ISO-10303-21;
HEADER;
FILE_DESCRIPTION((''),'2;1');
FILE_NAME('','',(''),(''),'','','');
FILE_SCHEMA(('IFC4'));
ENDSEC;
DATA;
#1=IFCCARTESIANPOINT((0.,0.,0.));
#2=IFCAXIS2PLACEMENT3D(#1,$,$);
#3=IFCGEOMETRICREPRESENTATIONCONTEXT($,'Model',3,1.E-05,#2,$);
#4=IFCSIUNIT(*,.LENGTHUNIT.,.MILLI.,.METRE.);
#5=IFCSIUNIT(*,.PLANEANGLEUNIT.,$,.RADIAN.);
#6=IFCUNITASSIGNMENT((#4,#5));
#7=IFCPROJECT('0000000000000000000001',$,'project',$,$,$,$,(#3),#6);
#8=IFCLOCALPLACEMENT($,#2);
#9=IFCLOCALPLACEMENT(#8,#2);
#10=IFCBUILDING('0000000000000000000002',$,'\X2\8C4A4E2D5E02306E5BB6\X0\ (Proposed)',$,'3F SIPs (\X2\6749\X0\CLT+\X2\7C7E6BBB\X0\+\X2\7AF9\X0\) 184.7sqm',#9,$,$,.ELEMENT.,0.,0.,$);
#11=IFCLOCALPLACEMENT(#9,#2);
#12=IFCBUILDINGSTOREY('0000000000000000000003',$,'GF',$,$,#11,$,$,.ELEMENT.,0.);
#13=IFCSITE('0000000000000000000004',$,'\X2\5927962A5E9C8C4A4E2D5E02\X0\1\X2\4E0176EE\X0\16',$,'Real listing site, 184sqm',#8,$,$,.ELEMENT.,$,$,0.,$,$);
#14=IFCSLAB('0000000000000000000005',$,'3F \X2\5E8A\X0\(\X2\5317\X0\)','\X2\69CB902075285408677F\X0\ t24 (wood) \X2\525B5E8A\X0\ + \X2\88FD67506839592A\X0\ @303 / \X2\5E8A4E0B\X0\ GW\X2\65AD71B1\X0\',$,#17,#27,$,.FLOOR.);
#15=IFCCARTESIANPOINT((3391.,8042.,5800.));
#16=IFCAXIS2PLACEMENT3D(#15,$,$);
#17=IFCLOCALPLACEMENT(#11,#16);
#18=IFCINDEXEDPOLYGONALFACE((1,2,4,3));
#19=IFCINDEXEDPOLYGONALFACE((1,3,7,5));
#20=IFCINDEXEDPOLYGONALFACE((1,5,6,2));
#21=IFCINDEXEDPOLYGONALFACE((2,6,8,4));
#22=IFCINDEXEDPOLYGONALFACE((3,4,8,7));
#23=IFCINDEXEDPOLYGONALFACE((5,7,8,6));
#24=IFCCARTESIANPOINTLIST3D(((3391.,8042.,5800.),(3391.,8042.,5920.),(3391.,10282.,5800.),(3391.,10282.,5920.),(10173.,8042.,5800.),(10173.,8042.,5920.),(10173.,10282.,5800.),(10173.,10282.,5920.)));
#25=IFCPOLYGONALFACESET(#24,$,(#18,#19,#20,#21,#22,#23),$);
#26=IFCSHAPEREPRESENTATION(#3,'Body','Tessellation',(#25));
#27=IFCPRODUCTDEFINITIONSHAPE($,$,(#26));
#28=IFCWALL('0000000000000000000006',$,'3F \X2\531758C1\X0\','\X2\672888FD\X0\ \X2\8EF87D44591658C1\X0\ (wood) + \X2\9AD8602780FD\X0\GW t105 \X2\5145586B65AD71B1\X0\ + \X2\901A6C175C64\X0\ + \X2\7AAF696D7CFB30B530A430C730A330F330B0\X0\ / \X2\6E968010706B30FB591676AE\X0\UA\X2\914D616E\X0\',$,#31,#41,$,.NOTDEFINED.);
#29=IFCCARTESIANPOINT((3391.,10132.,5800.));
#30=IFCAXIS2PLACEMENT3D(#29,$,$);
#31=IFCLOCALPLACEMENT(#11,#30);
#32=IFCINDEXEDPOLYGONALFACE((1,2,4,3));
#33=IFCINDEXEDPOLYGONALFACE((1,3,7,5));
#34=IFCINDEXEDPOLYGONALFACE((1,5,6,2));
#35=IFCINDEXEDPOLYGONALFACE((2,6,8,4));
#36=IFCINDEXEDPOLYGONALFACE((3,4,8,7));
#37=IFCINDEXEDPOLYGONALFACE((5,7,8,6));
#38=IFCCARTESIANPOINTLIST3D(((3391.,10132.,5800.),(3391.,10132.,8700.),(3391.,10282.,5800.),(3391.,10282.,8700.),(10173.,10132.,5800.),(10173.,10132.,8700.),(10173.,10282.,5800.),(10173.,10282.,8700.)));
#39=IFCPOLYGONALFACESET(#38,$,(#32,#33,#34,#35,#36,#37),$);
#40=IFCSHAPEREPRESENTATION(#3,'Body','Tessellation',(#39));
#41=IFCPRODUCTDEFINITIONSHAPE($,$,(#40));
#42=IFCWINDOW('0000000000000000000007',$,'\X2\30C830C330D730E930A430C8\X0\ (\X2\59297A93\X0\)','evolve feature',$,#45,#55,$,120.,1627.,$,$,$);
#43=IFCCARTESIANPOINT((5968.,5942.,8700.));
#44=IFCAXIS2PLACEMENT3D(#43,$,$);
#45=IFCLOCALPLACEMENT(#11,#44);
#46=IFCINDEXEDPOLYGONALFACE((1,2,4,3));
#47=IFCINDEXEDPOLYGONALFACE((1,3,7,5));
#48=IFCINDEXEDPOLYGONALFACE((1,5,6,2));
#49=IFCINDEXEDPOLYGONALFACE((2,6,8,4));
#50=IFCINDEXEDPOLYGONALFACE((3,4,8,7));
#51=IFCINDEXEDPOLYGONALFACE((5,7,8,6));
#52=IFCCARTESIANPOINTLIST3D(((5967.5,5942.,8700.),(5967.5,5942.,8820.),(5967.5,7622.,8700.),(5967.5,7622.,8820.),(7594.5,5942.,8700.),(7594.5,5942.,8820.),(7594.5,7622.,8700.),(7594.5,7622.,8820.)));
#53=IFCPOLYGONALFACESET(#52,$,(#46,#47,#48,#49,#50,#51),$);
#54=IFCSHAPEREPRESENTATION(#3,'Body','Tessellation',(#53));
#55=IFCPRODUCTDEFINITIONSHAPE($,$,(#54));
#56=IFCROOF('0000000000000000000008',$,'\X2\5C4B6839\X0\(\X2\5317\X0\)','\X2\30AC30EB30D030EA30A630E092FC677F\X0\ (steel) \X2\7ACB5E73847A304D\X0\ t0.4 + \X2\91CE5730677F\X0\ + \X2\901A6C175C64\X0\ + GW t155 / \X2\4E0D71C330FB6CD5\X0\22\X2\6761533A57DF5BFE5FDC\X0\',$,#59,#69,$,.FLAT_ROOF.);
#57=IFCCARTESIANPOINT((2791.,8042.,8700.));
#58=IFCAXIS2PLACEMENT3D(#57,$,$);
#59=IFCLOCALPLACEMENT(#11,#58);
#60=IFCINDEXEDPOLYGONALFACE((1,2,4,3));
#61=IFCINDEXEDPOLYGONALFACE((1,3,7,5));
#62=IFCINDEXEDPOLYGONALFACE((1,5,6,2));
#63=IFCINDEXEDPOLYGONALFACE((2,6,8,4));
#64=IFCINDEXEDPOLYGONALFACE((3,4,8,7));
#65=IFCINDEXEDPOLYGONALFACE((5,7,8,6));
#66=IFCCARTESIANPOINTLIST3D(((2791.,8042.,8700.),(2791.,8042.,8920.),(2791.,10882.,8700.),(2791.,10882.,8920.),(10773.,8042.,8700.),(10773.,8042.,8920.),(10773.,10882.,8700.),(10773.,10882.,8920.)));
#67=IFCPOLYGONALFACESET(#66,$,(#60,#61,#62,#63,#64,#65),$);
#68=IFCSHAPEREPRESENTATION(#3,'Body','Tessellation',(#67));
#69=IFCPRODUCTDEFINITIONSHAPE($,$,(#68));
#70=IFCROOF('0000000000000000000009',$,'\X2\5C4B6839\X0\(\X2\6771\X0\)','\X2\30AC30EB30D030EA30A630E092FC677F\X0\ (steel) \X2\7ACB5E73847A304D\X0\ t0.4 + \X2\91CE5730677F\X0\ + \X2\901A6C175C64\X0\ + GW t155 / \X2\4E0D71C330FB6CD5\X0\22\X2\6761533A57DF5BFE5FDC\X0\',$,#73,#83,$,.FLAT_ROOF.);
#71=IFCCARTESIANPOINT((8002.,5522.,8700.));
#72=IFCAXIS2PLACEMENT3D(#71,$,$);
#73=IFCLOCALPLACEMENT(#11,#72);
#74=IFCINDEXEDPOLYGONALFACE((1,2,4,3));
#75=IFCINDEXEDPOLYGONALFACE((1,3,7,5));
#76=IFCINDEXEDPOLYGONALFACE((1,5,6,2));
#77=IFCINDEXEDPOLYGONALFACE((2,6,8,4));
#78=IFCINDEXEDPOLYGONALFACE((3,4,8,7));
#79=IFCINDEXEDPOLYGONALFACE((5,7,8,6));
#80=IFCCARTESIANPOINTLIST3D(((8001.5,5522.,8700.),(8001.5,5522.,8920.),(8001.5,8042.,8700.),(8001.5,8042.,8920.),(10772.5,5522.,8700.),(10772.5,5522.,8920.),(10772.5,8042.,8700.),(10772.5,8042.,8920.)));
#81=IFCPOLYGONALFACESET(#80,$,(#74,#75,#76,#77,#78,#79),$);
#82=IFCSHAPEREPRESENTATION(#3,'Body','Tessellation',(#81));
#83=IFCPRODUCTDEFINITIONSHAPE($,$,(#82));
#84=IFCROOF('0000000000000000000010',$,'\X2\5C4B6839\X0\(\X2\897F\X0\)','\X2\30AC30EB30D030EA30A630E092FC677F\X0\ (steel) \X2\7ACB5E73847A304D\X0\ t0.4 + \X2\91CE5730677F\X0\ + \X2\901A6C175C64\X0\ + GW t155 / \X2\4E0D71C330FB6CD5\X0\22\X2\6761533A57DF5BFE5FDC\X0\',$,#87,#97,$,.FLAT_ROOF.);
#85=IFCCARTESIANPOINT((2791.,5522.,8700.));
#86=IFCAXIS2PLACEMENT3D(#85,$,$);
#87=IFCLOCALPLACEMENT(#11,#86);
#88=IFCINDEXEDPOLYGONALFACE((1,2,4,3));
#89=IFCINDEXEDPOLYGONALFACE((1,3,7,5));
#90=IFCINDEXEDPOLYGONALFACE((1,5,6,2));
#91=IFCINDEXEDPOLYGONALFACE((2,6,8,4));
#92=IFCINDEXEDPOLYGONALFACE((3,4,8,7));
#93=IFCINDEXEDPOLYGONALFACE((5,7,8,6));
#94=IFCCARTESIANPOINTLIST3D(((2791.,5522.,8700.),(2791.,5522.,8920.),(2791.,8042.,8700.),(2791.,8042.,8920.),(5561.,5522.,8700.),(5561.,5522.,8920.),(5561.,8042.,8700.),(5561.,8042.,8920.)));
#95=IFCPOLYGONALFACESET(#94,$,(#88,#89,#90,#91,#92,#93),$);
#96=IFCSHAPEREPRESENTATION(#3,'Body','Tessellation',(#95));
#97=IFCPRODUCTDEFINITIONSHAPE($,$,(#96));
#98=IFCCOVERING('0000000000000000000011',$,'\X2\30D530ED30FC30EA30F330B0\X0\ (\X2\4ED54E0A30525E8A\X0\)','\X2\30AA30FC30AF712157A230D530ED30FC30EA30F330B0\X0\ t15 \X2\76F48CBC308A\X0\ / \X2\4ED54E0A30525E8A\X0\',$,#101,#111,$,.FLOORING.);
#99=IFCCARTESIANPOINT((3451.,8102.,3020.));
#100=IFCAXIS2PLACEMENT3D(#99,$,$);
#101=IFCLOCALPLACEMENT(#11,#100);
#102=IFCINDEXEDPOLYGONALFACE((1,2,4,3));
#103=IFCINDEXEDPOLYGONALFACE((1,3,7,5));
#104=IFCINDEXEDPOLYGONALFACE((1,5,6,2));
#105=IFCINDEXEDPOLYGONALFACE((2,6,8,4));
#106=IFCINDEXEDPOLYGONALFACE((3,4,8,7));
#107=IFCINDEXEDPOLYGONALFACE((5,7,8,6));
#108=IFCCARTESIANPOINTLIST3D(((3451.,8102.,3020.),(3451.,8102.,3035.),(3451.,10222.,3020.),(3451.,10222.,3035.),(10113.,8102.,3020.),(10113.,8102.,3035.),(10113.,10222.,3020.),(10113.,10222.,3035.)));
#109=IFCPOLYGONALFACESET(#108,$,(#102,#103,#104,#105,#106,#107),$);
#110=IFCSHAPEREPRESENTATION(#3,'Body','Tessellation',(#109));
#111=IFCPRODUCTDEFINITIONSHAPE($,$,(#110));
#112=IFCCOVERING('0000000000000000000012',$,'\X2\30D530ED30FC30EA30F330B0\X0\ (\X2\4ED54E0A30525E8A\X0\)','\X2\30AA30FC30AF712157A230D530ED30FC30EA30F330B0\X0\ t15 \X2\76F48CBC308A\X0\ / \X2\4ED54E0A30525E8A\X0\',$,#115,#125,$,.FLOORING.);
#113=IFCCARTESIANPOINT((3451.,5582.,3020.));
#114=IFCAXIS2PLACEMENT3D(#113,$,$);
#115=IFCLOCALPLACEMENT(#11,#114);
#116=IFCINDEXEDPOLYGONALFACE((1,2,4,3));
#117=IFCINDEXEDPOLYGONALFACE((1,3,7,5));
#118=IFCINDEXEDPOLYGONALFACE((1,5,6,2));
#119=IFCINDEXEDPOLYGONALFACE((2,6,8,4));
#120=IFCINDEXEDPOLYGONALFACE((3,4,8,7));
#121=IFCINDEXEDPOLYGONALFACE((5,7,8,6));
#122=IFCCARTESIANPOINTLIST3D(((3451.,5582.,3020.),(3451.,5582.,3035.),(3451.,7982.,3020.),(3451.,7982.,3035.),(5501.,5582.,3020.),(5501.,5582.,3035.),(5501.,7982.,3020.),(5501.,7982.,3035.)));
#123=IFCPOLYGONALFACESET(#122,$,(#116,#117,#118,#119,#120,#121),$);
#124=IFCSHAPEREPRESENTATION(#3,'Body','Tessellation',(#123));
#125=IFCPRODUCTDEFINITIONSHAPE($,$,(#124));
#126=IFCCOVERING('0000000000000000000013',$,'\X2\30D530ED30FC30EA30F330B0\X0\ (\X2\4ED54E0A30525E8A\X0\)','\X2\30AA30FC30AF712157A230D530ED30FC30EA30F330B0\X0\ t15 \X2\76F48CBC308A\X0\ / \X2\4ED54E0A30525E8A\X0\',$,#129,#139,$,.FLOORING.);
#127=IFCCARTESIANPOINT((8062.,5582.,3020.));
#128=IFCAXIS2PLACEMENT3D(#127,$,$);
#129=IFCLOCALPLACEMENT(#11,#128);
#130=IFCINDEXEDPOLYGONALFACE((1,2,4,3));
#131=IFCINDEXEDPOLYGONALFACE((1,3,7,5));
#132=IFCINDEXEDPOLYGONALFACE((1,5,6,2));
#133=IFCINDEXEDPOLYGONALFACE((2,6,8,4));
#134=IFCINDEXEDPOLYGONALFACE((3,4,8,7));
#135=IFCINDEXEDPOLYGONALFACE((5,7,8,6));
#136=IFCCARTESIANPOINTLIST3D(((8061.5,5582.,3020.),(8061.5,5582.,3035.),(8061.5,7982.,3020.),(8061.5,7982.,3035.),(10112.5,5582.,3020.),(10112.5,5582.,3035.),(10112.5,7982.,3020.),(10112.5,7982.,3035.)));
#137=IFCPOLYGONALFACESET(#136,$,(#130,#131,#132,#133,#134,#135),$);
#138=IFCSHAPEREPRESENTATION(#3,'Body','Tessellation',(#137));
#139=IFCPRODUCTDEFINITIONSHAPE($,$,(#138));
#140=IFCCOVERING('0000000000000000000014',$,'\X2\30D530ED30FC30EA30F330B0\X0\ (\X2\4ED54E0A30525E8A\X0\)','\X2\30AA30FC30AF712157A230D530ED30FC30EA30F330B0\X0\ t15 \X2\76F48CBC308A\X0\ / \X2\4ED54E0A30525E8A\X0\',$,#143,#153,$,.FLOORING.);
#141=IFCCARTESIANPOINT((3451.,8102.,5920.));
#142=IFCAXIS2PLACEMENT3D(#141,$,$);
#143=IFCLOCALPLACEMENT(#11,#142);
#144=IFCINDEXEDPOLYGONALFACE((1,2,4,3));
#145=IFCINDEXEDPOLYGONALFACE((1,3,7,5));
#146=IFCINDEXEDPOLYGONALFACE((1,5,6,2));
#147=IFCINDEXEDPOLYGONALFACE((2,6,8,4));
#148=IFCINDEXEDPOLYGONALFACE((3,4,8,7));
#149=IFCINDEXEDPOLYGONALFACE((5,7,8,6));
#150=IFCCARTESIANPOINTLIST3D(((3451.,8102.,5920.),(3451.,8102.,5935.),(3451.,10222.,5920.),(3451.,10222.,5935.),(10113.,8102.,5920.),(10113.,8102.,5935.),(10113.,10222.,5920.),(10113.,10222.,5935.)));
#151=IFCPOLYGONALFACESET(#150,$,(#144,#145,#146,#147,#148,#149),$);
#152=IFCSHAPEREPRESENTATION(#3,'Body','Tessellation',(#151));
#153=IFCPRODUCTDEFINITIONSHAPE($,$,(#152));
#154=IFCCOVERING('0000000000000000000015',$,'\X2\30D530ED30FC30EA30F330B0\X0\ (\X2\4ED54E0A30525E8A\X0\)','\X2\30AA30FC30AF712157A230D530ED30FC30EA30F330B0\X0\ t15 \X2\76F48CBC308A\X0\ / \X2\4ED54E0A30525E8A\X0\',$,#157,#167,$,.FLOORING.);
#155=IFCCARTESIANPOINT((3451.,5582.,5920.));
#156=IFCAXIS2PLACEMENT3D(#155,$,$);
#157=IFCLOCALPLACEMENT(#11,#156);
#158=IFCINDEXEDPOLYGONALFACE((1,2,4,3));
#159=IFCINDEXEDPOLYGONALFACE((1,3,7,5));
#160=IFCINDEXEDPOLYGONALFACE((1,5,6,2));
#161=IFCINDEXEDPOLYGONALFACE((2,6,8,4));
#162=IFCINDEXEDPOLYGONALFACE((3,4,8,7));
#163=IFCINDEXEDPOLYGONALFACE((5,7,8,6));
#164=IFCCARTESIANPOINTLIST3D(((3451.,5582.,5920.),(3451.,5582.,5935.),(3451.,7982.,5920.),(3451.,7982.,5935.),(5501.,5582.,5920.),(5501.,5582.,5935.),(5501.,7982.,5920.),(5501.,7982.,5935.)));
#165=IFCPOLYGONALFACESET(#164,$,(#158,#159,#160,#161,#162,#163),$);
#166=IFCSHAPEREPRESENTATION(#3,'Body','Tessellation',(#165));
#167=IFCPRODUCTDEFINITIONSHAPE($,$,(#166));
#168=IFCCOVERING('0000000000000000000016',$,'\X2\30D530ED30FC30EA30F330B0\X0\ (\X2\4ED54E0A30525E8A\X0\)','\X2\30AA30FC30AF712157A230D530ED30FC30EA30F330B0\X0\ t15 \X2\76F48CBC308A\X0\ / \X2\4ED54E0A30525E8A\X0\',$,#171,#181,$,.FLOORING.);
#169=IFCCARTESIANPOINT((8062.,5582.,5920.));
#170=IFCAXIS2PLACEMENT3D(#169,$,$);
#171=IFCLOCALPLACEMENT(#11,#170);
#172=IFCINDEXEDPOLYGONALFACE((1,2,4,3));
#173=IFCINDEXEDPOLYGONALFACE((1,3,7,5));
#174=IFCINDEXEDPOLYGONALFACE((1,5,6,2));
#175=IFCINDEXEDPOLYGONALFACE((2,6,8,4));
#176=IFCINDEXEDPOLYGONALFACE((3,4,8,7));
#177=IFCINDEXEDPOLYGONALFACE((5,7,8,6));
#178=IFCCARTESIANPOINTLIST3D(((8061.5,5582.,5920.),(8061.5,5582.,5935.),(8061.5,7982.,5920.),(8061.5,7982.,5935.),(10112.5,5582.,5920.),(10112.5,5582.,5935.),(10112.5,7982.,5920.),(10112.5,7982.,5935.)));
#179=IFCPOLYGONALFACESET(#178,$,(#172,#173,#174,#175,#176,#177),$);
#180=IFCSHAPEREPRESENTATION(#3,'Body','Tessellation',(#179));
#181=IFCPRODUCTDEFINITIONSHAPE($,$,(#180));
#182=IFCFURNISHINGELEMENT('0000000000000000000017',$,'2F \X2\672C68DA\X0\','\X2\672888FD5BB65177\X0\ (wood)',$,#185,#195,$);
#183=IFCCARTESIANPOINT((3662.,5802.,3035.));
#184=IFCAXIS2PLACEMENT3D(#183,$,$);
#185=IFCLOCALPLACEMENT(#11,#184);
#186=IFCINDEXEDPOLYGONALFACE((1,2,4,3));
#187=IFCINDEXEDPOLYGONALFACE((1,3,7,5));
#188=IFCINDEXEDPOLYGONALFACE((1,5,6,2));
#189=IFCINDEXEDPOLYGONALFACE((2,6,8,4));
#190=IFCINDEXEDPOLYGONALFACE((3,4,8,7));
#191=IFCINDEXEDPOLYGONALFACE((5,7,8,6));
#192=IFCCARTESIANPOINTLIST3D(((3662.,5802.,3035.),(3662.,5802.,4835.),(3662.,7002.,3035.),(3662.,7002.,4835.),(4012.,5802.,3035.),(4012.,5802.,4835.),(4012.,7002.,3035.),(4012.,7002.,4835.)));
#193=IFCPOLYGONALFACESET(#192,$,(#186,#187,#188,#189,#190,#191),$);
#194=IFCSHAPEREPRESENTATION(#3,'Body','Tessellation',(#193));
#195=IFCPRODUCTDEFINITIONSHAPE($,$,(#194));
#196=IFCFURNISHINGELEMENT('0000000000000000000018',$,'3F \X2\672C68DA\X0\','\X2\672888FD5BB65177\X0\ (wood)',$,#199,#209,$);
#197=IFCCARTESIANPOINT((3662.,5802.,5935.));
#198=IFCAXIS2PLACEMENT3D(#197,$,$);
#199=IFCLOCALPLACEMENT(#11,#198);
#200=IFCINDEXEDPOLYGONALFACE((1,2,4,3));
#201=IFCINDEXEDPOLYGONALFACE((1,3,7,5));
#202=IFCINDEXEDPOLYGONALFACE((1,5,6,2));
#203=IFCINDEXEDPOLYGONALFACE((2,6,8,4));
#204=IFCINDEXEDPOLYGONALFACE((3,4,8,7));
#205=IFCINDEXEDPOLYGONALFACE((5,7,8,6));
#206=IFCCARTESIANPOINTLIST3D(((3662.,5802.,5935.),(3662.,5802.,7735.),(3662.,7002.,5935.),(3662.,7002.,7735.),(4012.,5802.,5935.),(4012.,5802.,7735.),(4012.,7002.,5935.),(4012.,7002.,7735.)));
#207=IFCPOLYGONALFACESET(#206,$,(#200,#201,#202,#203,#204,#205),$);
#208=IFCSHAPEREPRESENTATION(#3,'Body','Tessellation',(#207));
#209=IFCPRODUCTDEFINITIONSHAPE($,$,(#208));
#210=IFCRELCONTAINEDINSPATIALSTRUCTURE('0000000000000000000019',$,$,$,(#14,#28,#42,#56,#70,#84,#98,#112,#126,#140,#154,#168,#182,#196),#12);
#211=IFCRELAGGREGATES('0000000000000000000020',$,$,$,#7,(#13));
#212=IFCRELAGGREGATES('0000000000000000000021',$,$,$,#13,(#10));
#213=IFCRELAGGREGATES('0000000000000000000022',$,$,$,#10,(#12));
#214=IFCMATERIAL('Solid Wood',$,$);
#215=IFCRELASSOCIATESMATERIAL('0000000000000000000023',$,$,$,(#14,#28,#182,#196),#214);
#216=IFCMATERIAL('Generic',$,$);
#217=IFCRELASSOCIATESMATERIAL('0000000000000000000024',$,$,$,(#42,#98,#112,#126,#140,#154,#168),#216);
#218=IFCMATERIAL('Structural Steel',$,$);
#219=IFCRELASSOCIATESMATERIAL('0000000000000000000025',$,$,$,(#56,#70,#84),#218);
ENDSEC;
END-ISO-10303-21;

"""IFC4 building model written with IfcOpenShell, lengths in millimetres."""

from ifc_helpers import new_model, si_unit, frame, frame_2d, origin, place, context, project, spatial, rectangle, extrude, material, element, save


model = new_model("IFC4")

# Units and contexts
model_context = context("Model", 3, precision=1e-05, world=origin())
ifc_project = project(units=[si_unit("LENGTHUNIT", "METRE", prefix="MILLI"), si_unit("PLANEANGLEUNIT", "RADIAN")], contexts=[model_context])

# Site, building, storey
site_placement = place(None, origin())
site = spatial("IfcSite", under=ifc_project, at=site_placement, Name="大阪府豊中市1丁目16", ObjectType="Real listing site, 184sqm", CompositionType="ELEMENT", RefElevation=0.0)
building_placement = place(site_placement, origin())
building = spatial("IfcBuilding", under=site, at=building_placement, Name="豊中市の家 (Proposed)", ObjectType="3F SIPs (杉CLT+籾殻+竹) 184.7sqm", CompositionType="ELEMENT", ElevationOfRefHeight=0.0, ElevationOfTerrain=0.0)
storey_placement = place(building_placement, origin())
storey = spatial("IfcBuildingStorey", under=building, at=storey_placement, Name="GF", CompositionType="ELEMENT", Elevation=0.0)

# Slab
ifc_material_1 = material(Name="Solid Wood")
slab_placement = place(storey_placement, frame((3391.0, 8042.0, 5800.0)))
element("IfcSlab", 1, at=slab_placement, inside=storey, material=ifc_material_1, Name="3F 床(北)", Description="構造用合板 t24 (wood) 剛床 + 製材根太 @303 / 床下 GW断熱", PredefinedType="FLOOR", context=model_context, shape_type="SweptSolid", body=[
    extrude(rectangle(XDim=6782.0, YDim=2240.0, at=frame_2d((3391.0, 1120.0))), frame((3391.0, 8042.0, 5800.0)), (0.0, 0.0, 1.0), 120.0),
])

# Wall
wall_1_placement = place(storey_placement, frame((3391.0, 10132.0, 5800.0)))
element("IfcWall", 2, at=wall_1_placement, inside=storey, material=ifc_material_1, Name="3F 北壁", Description="木製 軸組外壁 (wood) + 高性能GW t105 充填断熱 + 通気層 + 窯業系サイディング / 準耐火・外皮UA配慮", PredefinedType="NOTDEFINED", context=model_context, shape_type="SweptSolid", body=[
    extrude(rectangle(XDim=6782.0, YDim=150.0, at=frame_2d((3391.0, 75.0))), frame((3391.0, 10132.0, 5800.0)), (0.0, 0.0, 1.0), 2900.0),
])

# Window
ifc_material_2 = material(Name="Generic")
window_1_placement = place(storey_placement, frame((5968.0, 5942.0, 8700.0)))
element("IfcWindow", 3, at=window_1_placement, inside=storey, material=ifc_material_2, Name="トップライト (天窓)", Description="evolve feature", OverallHeight=120.0, OverallWidth=1627.0, context=model_context, shape_type="SweptSolid", body=[
    extrude(rectangle(XDim=1627.0, YDim=1680.0, at=frame_2d((813.0, 840.0))), frame((5968.0, 5942.0, 8700.0)), (0.0, 0.0, 1.0), 120.0),
])

# Roofs
ifc_material_3 = material(Name="Structural Steel")
roof_1_placement = place(storey_placement, frame((2791.0, 8042.0, 8700.0)))
element("IfcRoof", 4, at=roof_1_placement, inside=storey, material=ifc_material_3, Name="屋根(北)", Description="ガルバリウム鋼板 (steel) 立平葺き t0.4 + 野地板 + 通気層 + GW t155 / 不燃・法22条区域対応", PredefinedType="FLAT_ROOF", context=model_context, shape_type="SweptSolid", body=[
    extrude(rectangle(XDim=7982.0, YDim=2840.0, at=frame_2d((3991.0, 1420.0))), frame((2791.0, 8042.0, 8700.0)), (0.0, 0.0, 1.0), 220.0),
])
roof_2_placement = place(storey_placement, frame((8002.0, 5522.0, 8700.0)))
element("IfcRoof", 5, at=roof_2_placement, inside=storey, material=ifc_material_3, Name="屋根(東)", Description="ガルバリウム鋼板 (steel) 立平葺き t0.4 + 野地板 + 通気層 + GW t155 / 不燃・法22条区域対応", PredefinedType="FLAT_ROOF", context=model_context, shape_type="SweptSolid", body=[
    extrude(rectangle(XDim=2771.0, YDim=2520.0, at=frame_2d((1385.0, 1260.0))), frame((8002.0, 5522.0, 8700.0)), (0.0, 0.0, 1.0), 220.0),
])
roof_3_placement = place(storey_placement, frame((2791.0, 5522.0, 8700.0)))
element("IfcRoof", 6, at=roof_3_placement, inside=storey, material=ifc_material_3, Name="屋根(西)", Description="ガルバリウム鋼板 (steel) 立平葺き t0.4 + 野地板 + 通気層 + GW t155 / 不燃・法22条区域対応", PredefinedType="FLAT_ROOF", context=model_context, shape_type="SweptSolid", body=[
    extrude(rectangle(XDim=2770.0, YDim=2520.0, at=frame_2d((1385.0, 1260.0))), frame((2791.0, 5522.0, 8700.0)), (0.0, 0.0, 1.0), 220.0),
])

# Coverings
covering_1_placement = place(storey_placement, frame((3451.0, 8102.0, 3020.0)))
element("IfcCovering", 7, at=covering_1_placement, inside=storey, material=ifc_material_2, Name="フローリング (仕上げ床)", Description="オーク無垢フローリング t15 直貼り / 仕上げ床", PredefinedType="FLOORING", context=model_context, shape_type="SweptSolid", body=[
    extrude(rectangle(XDim=6662.0, YDim=2120.0, at=frame_2d((3331.0, 1060.0))), frame((3451.0, 8102.0, 3020.0)), (0.0, 0.0, 1.0), 15.0),
])
covering_2_placement = place(storey_placement, frame((3451.0, 5582.0, 3020.0)))
element("IfcCovering", 8, at=covering_2_placement, inside=storey, material=ifc_material_2, Name="フローリング (仕上げ床)", Description="オーク無垢フローリング t15 直貼り / 仕上げ床", PredefinedType="FLOORING", context=model_context, shape_type="SweptSolid", body=[
    extrude(rectangle(XDim=2050.0, YDim=2400.0, at=frame_2d((1025.0, 1200.0))), frame((3451.0, 5582.0, 3020.0)), (0.0, 0.0, 1.0), 15.0),
])
covering_3_placement = place(storey_placement, frame((8062.0, 5582.0, 3020.0)))
element("IfcCovering", 9, at=covering_3_placement, inside=storey, material=ifc_material_2, Name="フローリング (仕上げ床)", Description="オーク無垢フローリング t15 直貼り / 仕上げ床", PredefinedType="FLOORING", context=model_context, shape_type="SweptSolid", body=[
    extrude(rectangle(XDim=2051.0, YDim=2400.0, at=frame_2d((1025.0, 1200.0))), frame((8062.0, 5582.0, 3020.0)), (0.0, 0.0, 1.0), 15.0),
])
covering_4_placement = place(storey_placement, frame((3451.0, 8102.0, 5920.0)))
element("IfcCovering", 10, at=covering_4_placement, inside=storey, material=ifc_material_2, Name="フローリング (仕上げ床)", Description="オーク無垢フローリング t15 直貼り / 仕上げ床", PredefinedType="FLOORING", context=model_context, shape_type="SweptSolid", body=[
    extrude(rectangle(XDim=6662.0, YDim=2120.0, at=frame_2d((3331.0, 1060.0))), frame((3451.0, 8102.0, 5920.0)), (0.0, 0.0, 1.0), 15.0),
])
covering_5_placement = place(storey_placement, frame((3451.0, 5582.0, 5920.0)))
element("IfcCovering", 11, at=covering_5_placement, inside=storey, material=ifc_material_2, Name="フローリング (仕上げ床)", Description="オーク無垢フローリング t15 直貼り / 仕上げ床", PredefinedType="FLOORING", context=model_context, shape_type="SweptSolid", body=[
    extrude(rectangle(XDim=2050.0, YDim=2400.0, at=frame_2d((1025.0, 1200.0))), frame((3451.0, 5582.0, 5920.0)), (0.0, 0.0, 1.0), 15.0),
])
covering_6_placement = place(storey_placement, frame((8062.0, 5582.0, 5920.0)))
element("IfcCovering", 12, at=covering_6_placement, inside=storey, material=ifc_material_2, Name="フローリング (仕上げ床)", Description="オーク無垢フローリング t15 直貼り / 仕上げ床", PredefinedType="FLOORING", context=model_context, shape_type="SweptSolid", body=[
    extrude(rectangle(XDim=2051.0, YDim=2400.0, at=frame_2d((1025.0, 1200.0))), frame((8062.0, 5582.0, 5920.0)), (0.0, 0.0, 1.0), 15.0),
])

# Furnishing elements
furnishing_1_placement = place(storey_placement, frame((3662.0, 5802.0, 3035.0)))
element("IfcFurnishingElement", 13, at=furnishing_1_placement, inside=storey, material=ifc_material_1, Name="2F 本棚", Description="木製家具 (wood)", context=model_context, shape_type="SweptSolid", body=[
    extrude(rectangle(XDim=350.0, YDim=1200.0, at=frame_2d((175.0, 600.0))), frame((3662.0, 5802.0, 3035.0)), (0.0, 0.0, 1.0), 1800.0),
])
furnishing_2_placement = place(storey_placement, frame((3662.0, 5802.0, 5935.0)))
element("IfcFurnishingElement", 14, at=furnishing_2_placement, inside=storey, material=ifc_material_1, Name="3F 本棚", Description="木製家具 (wood)", context=model_context, shape_type="SweptSolid", body=[
    extrude(rectangle(XDim=350.0, YDim=1200.0, at=frame_2d((175.0, 600.0))), frame((3662.0, 5802.0, 5935.0)), (0.0, 0.0, 1.0), 1800.0),
])

save(model, "model.ifc")
